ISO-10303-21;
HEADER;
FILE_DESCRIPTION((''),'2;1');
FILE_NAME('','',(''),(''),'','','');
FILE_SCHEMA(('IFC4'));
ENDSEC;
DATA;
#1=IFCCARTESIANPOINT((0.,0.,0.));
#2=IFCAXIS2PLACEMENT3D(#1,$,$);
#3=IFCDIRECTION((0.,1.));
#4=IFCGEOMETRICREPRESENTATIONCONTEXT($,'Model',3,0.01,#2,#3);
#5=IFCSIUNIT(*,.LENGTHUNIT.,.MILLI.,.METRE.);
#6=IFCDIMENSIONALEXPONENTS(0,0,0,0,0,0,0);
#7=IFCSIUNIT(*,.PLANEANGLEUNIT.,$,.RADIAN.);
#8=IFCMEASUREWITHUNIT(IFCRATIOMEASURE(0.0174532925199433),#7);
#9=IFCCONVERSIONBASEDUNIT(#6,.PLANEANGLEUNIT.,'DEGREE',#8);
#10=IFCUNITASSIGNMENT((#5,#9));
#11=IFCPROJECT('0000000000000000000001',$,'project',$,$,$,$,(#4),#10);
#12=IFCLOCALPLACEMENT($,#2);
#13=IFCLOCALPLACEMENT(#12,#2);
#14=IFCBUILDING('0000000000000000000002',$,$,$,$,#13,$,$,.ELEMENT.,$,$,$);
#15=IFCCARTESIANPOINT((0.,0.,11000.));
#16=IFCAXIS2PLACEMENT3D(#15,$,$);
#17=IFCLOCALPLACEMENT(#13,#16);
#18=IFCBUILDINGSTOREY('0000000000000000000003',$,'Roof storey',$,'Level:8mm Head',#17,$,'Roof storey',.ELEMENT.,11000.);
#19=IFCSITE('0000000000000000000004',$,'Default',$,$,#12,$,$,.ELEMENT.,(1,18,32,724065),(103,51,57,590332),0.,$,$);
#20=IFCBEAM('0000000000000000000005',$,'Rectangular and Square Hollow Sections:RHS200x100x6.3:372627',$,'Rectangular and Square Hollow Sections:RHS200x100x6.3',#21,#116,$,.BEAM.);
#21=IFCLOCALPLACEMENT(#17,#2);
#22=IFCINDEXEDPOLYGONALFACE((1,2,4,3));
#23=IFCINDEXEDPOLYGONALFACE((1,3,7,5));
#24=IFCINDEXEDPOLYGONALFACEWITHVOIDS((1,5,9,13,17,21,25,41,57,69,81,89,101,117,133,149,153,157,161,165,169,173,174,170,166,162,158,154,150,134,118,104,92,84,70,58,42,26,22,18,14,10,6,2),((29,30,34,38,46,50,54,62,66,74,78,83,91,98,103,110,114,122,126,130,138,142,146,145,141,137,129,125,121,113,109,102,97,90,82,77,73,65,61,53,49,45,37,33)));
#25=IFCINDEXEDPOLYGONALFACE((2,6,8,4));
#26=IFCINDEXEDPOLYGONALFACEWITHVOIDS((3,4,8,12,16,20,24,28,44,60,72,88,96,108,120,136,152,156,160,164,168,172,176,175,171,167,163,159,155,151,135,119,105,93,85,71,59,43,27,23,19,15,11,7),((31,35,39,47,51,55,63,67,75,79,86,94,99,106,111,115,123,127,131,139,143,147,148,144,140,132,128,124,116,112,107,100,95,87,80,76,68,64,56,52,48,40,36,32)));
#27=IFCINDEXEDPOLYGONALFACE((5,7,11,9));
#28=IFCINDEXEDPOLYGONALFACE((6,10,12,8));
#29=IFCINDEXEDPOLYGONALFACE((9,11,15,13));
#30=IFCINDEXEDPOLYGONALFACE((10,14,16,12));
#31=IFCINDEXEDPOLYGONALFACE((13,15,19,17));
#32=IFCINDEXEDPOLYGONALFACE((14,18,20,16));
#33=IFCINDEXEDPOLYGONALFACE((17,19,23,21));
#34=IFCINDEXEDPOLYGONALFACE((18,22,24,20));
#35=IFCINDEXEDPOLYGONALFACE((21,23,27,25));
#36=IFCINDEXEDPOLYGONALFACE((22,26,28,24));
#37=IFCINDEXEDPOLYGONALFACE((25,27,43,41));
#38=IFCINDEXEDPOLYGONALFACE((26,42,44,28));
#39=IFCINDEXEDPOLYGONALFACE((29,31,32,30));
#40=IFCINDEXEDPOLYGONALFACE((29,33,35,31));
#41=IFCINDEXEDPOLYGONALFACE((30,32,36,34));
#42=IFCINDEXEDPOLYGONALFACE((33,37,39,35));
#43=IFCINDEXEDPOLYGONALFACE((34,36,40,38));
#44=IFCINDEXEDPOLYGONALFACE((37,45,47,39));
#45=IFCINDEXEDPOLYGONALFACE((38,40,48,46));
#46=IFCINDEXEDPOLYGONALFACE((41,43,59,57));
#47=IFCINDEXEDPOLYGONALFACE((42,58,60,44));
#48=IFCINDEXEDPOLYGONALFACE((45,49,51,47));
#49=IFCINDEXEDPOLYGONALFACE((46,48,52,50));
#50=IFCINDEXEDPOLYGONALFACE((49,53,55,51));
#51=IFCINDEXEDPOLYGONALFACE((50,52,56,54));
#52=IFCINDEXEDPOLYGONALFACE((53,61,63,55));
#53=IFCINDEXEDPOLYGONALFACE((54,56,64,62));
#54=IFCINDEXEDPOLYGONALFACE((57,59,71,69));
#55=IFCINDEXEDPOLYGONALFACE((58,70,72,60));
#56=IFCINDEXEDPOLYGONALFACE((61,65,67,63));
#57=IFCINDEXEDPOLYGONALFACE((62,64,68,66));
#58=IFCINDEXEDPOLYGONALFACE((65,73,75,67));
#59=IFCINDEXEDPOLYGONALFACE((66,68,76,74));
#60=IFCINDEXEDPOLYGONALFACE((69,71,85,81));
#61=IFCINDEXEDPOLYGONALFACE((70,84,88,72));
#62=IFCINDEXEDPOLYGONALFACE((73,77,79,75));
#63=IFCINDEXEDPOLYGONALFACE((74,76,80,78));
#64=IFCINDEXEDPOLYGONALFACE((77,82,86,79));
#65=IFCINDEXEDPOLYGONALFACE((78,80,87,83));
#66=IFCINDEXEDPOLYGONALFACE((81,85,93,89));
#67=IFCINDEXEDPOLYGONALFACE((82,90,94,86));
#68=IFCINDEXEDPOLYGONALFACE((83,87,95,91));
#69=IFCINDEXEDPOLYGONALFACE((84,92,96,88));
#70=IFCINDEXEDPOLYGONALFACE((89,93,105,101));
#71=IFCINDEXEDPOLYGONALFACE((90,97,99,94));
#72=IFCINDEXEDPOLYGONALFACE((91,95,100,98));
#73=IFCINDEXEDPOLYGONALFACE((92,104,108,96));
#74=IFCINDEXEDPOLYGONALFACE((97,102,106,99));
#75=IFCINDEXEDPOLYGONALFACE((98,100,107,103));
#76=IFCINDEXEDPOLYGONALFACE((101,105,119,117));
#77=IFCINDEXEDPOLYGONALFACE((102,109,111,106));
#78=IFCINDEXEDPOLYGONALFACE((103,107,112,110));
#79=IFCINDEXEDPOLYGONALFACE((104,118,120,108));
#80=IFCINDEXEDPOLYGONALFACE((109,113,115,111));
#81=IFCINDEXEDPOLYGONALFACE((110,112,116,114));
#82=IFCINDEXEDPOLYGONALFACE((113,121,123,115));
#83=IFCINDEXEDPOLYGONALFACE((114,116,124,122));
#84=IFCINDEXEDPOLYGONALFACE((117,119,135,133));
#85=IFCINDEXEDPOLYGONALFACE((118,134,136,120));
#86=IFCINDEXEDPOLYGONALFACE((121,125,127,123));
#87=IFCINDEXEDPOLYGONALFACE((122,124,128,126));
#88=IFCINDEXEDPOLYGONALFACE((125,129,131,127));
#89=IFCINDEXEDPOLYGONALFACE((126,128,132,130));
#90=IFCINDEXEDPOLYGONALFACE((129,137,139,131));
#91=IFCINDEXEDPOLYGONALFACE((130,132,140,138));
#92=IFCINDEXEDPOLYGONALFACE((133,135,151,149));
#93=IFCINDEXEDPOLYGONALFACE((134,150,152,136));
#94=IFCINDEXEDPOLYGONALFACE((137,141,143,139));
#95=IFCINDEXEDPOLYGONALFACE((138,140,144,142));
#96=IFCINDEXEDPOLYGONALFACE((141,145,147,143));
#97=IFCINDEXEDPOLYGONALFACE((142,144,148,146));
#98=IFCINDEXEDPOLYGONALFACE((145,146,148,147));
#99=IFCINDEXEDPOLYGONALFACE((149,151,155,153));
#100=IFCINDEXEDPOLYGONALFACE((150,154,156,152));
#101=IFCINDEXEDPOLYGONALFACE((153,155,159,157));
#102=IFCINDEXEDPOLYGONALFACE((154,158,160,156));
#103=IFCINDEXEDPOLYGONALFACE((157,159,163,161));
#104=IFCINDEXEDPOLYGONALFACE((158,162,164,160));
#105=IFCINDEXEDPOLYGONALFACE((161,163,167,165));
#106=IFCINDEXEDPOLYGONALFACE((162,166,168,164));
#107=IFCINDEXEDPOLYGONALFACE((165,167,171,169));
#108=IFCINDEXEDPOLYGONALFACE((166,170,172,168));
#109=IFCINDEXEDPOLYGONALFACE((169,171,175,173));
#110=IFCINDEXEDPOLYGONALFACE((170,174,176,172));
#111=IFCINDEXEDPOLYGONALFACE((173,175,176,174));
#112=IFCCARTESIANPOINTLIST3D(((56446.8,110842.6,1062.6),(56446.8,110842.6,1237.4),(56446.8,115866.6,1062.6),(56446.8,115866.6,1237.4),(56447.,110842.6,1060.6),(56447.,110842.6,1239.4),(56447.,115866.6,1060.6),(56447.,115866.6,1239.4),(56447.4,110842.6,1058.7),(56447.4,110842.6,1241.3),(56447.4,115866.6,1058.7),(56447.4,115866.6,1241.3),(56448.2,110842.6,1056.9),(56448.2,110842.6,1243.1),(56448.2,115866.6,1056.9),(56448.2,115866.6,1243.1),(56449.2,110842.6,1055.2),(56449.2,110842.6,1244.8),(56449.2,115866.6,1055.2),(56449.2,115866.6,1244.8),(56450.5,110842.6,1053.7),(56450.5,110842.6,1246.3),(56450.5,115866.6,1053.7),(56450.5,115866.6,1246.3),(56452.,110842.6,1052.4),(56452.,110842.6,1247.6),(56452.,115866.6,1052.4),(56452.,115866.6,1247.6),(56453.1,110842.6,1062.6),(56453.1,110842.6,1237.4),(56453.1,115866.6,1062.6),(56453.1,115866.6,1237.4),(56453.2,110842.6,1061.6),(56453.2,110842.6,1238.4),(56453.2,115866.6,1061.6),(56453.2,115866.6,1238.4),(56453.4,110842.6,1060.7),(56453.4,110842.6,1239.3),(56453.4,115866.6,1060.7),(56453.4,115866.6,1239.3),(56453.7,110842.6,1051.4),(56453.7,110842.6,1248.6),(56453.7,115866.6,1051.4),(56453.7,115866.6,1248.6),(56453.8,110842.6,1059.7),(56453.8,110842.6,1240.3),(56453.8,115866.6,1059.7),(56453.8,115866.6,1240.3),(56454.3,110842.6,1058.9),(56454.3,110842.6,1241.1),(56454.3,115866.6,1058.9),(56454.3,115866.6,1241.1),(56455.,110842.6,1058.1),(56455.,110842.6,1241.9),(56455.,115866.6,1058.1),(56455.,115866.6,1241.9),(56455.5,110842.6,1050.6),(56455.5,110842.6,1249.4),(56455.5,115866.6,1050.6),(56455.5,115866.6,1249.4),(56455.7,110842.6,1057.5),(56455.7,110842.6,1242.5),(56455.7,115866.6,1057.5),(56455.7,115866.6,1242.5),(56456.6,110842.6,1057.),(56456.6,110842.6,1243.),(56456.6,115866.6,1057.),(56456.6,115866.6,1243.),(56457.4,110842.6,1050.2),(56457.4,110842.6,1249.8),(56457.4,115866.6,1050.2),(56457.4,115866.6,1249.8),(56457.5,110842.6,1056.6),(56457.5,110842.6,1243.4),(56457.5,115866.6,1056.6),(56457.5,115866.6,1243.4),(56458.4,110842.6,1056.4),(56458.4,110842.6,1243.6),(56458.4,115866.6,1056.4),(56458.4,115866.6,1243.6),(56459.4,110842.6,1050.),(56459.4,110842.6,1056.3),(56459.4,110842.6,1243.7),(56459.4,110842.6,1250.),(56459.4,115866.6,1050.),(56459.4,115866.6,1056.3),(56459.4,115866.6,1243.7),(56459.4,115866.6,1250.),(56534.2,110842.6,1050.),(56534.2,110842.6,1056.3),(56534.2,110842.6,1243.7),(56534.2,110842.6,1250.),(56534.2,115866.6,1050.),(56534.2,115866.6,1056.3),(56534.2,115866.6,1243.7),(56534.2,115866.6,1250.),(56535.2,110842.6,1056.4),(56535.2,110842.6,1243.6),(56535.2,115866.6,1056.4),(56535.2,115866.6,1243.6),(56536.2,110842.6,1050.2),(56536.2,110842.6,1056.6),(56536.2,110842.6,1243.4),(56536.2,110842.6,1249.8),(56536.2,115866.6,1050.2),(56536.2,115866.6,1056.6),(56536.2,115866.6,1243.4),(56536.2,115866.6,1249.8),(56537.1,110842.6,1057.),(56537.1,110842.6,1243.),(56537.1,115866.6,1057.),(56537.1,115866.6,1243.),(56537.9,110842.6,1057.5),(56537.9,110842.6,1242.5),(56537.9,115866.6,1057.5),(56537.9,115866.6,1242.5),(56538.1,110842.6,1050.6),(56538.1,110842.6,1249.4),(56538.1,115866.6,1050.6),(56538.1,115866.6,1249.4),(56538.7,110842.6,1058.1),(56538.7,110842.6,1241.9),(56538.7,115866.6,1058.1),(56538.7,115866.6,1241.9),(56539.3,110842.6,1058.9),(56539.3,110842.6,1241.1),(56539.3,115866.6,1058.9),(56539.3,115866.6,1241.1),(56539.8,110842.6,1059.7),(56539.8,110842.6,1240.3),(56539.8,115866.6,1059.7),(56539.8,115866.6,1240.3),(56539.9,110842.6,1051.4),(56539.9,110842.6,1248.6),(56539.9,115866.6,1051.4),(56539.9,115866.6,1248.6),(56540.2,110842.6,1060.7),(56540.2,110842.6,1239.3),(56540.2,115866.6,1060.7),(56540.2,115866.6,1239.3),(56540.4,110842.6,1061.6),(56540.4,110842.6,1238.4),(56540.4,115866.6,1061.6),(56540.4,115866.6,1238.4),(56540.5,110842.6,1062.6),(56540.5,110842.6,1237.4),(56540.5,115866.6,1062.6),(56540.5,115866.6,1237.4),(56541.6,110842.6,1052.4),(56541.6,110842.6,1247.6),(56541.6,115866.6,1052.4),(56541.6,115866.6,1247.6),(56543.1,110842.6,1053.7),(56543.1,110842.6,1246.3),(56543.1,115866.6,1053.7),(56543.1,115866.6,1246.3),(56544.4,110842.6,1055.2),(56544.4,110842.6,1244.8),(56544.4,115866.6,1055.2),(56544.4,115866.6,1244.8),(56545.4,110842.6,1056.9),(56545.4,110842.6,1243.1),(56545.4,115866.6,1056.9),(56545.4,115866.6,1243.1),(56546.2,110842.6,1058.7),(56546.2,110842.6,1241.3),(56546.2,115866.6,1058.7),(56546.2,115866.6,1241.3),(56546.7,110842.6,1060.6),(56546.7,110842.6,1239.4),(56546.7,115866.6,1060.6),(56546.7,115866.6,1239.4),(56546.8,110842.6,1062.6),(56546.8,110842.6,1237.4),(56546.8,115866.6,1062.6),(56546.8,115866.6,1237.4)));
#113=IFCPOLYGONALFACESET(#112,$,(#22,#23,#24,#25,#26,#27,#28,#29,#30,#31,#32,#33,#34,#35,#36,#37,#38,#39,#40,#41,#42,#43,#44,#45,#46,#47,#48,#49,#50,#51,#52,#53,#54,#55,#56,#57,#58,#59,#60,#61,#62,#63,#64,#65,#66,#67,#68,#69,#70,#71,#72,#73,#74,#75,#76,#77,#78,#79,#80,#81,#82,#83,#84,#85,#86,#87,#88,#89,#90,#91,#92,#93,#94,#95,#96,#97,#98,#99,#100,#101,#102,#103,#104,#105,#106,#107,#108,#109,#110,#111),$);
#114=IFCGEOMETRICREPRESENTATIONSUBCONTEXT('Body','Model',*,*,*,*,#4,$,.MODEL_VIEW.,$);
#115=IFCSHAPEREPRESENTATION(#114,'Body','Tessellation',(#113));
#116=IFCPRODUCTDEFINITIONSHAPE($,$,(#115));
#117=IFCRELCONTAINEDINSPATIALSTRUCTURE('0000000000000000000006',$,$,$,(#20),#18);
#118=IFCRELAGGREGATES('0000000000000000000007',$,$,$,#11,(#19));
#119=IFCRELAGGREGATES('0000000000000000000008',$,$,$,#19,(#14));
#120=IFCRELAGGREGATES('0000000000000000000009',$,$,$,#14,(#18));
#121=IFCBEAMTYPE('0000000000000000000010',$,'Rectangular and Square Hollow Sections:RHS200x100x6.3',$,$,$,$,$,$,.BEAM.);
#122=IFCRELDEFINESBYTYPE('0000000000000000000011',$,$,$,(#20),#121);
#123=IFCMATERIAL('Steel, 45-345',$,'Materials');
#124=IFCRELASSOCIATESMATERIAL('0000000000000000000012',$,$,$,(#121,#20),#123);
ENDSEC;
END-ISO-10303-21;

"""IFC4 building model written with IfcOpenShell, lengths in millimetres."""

from ifc_helpers import new_model, entity, si_unit, converted_unit, direction, frame, origin, place, context, subcontext, project, spatial, indexed_curve, outline, extrude, source, transform, mapped, material, type_object, type_shapes, element, save


model = new_model("IFC4")

# Units and contexts
model_context = context("Model", 3, precision=0.01, world=origin(), true_north=direction((0.0, 1.0)))
body_context = subcontext(model_context, "Body", "Model", "MODEL_VIEW")
ifc_project = project(units=[si_unit("LENGTHUNIT", "METRE", prefix="MILLI"), converted_unit("PLANEANGLEUNIT", "DEGREE", entity("IfcRatioMeasure", 0.0174532925199433), si_unit("PLANEANGLEUNIT", "RADIAN"), dimensions=[0, 0, 0, 0, 0, 0, 0])], contexts=[model_context])

# Site, building, storey
site_placement = place(None, origin())
site = spatial("IfcSite", under=ifc_project, at=site_placement, Name="Default", CompositionType="ELEMENT", RefLatitude=(1, 18, 32, 724065), RefLongitude=(103, 51, 57, 590332), RefElevation=0.0)
building_placement = place(site_placement, origin())
building = spatial("IfcBuilding", under=site, at=building_placement, CompositionType="ELEMENT")
storey_placement = place(building_placement, frame((0.0, 0.0, 11000.0)))
storey = spatial("IfcBuildingStorey", under=building, at=storey_placement, Name="Roof storey", ObjectType="Level:8mm Head", LongName="Roof storey", CompositionType="ELEMENT", Elevation=11000.0)

# Shared definitions
ifc_material = material(Name="Steel, 45-345", Category="Materials")

# Beam
beam_type_1 = type_object("IfcBeamType", Name="Rectangular and Square Hollow Sections:RHS200x100x6.3", PredefinedType="BEAM", material=ifc_material)
shared_shape_1 = source(origin(), body_context, "Body", "SweptSolid", [
    extrude(outline(indexed_curve([(-50.0, -87.4), (-49.8, -89.4), (-49.4, -91.3), (-48.6, -93.1), (-47.6, -94.8), (-46.3, -96.3), (-44.8, -97.6), (-43.1, -98.6), (-41.3, -99.4), (-39.4, -99.8), (-37.4, -100.0), (37.4, -100.0), (39.4, -99.8), (41.3, -99.4), (43.1, -98.6), (44.8, -97.6), (46.3, -96.3), (47.6, -94.8), (48.6, -93.1), (49.4, -91.3), (49.8, -89.4), (50.0, -87.4), (50.0, 87.4), (49.8, 89.4), (49.4, 91.3), (48.6, 93.1), (47.6, 94.8), (46.3, 96.3), (44.8, 97.6), (43.1, 98.6), (41.3, 99.4), (39.4, 99.8), (37.4, 100.0), (-37.4, 100.0), (-39.4, 99.8), (-41.3, 99.4), (-43.1, 98.6), (-44.8, 97.6), (-46.3, 96.3), (-47.6, 94.8), (-48.6, 93.1), (-49.4, 91.3), (-49.8, 89.4), (-50.0, 87.4), (-50.0, -87.4)], self_intersect=False), holes=[indexed_curve([(37.4, -93.7), (-37.4, -93.7), (-38.4, -93.6), (-39.3, -93.4), (-40.3, -93.0), (-41.1, -92.5), (-41.9, -91.9), (-42.5, -91.1), (-43.0, -90.3), (-43.4, -89.3), (-43.6, -88.4), (-43.7, -87.4), (-43.7, 87.4), (-43.6, 88.4), (-43.4, 89.3), (-43.0, 90.3), (-42.5, 91.1), (-41.9, 91.9), (-41.1, 92.5), (-40.3, 93.0), (-39.3, 93.4), (-38.4, 93.6), (-37.4, 93.7), (37.4, 93.7), (38.4, 93.6), (39.3, 93.4), (40.3, 93.0), (41.1, 92.5), (41.9, 91.9), (42.5, 91.1), (43.0, 90.3), (43.4, 89.3), (43.6, 88.4), (43.7, 87.4), (43.7, -87.4), (43.6, -88.4), (43.4, -89.3), (43.0, -90.3), (42.5, -91.1), (41.9, -91.9), (41.1, -92.5), (40.3, -93.0), (39.3, -93.4), (38.4, -93.6), (37.4, -93.7)], self_intersect=False)]), frame((-2474.5, 0.0, 0.0), z_axis=(1.0, 0.0, 0.0), x_axis=(0.0, -1.0, 0.0)), (0.0, 0.0, 1.0), 5024.0),
])
type_shapes(beam_type_1, [shared_shape_1])
beam_1_placement = place(storey_placement, frame((56496.8, 113317.1, 1150.0), z_axis=(0.0, 0.0, 1.0), x_axis=(0.0, 1.0, 0.0)))
element("IfcBeam", 1, at=beam_1_placement, inside=storey, type_object=beam_type_1, material=ifc_material, Name="Rectangular and Square Hollow Sections:RHS200x100x6.3:372627", ObjectType="Rectangular and Square Hollow Sections:RHS200x100x6.3", PredefinedType="BEAM", context=body_context, shape_type="MappedRepresentation", body=[
    mapped(shared_shape_1, transform((0.0, 0.0, 0.0), scale=1.0)),
])

save(model, "model.ifc")
